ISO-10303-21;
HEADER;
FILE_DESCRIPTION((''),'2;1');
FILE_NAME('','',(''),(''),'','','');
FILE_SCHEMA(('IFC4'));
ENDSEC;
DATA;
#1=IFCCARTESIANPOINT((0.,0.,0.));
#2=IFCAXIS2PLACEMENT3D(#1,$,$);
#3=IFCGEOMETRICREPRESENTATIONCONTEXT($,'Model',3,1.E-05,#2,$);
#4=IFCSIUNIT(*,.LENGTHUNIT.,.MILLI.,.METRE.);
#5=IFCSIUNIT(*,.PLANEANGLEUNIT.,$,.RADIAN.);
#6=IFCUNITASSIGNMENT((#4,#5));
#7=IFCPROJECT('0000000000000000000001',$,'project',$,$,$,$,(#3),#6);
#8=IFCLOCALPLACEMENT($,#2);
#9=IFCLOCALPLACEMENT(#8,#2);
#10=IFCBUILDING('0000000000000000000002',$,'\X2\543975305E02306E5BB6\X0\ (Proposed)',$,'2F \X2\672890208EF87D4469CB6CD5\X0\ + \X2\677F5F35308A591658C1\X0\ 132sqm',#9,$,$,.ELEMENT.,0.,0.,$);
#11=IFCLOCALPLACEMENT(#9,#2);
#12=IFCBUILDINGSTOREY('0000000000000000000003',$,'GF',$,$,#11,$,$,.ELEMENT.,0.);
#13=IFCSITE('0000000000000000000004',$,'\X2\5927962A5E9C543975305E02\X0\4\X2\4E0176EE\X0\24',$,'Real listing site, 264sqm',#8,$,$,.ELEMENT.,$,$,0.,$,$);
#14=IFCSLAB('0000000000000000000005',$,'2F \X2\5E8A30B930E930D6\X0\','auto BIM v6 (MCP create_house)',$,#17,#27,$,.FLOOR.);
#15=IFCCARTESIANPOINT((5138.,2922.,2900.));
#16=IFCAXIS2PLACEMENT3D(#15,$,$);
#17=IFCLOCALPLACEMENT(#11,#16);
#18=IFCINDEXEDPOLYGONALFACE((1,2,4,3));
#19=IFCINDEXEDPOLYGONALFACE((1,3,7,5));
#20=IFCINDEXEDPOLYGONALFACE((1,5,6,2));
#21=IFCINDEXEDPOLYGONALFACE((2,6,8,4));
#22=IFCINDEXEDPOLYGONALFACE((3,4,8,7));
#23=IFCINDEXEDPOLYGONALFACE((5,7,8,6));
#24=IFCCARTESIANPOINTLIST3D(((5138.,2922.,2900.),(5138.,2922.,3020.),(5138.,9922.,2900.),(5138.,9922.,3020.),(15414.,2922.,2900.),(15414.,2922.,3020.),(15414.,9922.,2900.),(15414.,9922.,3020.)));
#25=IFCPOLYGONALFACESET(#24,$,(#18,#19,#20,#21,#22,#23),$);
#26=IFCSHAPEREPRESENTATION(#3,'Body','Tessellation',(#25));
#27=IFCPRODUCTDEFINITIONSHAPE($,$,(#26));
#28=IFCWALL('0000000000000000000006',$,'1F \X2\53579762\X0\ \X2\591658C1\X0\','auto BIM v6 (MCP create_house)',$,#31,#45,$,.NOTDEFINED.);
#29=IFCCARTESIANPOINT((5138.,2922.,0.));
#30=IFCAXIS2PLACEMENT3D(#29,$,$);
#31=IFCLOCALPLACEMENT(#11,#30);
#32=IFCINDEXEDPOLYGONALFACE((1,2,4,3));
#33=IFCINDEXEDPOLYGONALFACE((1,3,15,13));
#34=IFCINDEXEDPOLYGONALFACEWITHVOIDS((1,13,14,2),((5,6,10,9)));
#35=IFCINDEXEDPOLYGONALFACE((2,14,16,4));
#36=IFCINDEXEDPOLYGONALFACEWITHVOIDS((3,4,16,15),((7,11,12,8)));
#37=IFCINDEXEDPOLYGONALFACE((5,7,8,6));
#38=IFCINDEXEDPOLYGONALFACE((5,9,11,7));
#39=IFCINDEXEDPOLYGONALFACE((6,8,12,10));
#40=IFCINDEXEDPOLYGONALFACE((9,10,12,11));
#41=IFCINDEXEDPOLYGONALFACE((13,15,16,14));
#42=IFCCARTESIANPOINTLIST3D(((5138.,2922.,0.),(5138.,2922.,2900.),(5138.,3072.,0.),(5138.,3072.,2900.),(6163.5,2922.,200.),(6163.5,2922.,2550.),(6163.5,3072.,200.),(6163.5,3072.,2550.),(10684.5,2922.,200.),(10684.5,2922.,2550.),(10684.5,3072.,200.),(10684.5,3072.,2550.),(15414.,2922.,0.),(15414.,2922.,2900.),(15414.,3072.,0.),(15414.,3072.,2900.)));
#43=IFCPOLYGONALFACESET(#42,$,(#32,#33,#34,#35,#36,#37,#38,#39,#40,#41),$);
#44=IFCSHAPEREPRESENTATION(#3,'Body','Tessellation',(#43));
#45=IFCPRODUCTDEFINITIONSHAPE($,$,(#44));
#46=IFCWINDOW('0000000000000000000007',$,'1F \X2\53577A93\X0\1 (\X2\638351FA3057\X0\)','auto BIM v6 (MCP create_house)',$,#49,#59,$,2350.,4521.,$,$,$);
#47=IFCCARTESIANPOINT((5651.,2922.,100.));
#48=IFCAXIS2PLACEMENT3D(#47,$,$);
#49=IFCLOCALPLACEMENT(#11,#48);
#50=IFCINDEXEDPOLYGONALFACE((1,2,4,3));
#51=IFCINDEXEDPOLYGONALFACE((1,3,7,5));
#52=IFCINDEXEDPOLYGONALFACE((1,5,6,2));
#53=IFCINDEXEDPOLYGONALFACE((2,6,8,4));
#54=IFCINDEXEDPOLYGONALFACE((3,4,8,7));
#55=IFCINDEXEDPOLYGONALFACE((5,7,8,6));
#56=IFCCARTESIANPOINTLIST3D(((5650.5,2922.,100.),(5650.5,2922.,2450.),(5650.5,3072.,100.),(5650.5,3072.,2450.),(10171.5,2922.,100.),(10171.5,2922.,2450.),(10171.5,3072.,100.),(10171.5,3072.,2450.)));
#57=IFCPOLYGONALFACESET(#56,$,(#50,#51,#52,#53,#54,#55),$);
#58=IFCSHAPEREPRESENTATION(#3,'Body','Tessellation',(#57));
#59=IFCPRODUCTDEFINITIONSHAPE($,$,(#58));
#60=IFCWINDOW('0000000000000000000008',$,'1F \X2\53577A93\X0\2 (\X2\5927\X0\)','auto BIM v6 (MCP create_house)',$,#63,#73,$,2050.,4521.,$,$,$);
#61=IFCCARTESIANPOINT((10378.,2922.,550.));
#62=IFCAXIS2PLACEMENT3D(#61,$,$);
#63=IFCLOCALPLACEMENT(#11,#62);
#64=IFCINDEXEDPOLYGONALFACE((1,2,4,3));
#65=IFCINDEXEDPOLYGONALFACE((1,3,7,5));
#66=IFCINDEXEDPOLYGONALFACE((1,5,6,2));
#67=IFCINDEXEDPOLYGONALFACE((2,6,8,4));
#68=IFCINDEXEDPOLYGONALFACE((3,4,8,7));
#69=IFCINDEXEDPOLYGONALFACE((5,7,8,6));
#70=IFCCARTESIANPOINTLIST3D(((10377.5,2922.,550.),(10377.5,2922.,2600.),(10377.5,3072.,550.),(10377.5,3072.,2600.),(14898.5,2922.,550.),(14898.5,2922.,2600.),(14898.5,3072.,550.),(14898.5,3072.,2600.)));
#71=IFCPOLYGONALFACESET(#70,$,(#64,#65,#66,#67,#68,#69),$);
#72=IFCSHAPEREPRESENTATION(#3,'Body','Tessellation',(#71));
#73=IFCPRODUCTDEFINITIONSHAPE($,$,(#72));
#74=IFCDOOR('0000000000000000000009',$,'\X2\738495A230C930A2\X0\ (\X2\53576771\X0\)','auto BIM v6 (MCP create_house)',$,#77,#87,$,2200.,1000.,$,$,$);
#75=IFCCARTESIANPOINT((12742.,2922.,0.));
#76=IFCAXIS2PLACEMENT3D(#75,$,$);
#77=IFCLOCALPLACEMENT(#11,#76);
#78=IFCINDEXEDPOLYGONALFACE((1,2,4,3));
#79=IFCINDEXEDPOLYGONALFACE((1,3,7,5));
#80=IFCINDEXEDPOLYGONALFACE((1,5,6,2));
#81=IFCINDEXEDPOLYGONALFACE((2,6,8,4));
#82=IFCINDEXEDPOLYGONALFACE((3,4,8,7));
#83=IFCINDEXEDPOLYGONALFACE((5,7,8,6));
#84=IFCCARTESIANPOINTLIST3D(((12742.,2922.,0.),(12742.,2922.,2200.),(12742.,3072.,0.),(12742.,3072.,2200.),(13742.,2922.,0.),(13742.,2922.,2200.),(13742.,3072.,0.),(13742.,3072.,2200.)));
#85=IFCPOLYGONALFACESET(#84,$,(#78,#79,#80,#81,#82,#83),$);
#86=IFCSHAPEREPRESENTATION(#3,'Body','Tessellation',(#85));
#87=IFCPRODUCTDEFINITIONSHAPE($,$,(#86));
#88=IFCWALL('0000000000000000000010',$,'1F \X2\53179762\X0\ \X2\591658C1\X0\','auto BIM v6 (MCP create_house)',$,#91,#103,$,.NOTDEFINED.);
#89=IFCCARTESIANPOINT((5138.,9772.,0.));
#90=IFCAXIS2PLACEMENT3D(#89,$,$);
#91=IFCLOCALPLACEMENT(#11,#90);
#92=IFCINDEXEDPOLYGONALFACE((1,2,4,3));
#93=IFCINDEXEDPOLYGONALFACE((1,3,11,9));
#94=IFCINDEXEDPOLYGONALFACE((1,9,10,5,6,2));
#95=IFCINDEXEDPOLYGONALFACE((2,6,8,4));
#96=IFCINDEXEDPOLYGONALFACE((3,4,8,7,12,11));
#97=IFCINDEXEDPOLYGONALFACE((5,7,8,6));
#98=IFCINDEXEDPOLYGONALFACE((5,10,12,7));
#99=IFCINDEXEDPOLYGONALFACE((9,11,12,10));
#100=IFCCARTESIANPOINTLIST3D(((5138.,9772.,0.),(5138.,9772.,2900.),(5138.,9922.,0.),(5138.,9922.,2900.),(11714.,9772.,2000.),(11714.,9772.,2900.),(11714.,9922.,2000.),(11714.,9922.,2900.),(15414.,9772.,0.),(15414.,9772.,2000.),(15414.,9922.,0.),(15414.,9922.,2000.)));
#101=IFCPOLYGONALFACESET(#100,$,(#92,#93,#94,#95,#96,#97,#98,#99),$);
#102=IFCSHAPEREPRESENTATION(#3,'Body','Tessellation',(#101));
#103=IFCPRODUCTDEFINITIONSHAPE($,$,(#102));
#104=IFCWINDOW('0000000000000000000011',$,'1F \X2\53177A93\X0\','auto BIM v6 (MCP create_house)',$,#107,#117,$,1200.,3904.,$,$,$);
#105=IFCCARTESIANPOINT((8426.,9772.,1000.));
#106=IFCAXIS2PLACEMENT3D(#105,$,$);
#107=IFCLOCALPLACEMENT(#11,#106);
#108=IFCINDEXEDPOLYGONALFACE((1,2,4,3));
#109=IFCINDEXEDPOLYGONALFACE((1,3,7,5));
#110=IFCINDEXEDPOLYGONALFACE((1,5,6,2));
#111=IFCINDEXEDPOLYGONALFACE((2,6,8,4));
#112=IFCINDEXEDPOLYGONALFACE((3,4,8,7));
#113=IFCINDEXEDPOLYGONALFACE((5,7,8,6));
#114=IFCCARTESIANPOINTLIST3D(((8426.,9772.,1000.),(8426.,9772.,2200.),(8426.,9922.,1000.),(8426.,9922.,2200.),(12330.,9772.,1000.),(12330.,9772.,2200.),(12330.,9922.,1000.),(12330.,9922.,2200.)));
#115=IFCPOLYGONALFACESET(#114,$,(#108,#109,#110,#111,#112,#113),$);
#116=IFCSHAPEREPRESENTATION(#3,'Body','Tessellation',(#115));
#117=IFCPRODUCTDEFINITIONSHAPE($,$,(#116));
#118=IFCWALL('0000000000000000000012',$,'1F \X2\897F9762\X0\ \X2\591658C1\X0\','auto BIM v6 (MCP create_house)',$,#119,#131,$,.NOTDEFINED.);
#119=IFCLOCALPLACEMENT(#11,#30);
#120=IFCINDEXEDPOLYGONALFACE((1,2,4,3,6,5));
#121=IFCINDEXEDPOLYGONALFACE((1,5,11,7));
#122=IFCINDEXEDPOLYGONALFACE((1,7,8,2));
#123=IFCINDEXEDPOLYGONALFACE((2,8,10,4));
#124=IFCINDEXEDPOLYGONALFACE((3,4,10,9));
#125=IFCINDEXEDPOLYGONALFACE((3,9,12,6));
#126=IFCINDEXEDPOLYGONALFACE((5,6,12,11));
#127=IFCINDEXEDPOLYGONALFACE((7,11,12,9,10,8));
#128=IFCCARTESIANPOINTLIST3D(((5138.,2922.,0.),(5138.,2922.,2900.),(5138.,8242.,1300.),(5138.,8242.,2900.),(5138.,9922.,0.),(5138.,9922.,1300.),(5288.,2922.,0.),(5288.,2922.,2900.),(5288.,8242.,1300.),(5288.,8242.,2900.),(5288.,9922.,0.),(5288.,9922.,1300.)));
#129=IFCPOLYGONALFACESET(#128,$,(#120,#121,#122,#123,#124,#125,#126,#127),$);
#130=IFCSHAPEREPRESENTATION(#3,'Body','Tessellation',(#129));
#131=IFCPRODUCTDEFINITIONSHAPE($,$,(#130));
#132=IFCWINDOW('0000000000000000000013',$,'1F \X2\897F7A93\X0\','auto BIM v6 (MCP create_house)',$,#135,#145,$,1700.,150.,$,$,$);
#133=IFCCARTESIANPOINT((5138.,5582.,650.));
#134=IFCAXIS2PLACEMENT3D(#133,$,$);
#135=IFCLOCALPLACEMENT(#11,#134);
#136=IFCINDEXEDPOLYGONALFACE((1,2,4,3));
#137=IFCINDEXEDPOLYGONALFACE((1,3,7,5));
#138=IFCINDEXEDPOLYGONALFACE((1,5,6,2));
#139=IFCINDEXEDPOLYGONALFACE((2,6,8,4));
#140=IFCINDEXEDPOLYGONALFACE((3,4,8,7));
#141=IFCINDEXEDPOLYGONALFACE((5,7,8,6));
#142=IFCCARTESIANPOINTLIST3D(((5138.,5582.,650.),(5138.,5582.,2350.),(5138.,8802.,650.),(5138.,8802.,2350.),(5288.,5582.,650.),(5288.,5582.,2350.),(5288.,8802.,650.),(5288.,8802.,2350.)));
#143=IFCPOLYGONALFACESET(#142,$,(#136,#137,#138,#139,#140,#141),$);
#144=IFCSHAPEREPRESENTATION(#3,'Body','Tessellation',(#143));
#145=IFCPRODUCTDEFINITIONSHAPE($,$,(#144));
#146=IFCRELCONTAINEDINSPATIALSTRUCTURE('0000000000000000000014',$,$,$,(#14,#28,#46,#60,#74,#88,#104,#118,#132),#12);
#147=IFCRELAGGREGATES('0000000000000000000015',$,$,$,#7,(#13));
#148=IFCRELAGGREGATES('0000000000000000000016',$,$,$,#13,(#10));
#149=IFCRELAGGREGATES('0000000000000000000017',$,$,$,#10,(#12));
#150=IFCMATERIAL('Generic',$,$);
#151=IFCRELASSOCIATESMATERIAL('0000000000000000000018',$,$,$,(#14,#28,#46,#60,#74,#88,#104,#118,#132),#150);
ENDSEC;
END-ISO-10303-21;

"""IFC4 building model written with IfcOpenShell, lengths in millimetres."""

from ifc_helpers import new_model, si_unit, frame, frame_2d, origin, place, context, project, spatial, rectangle, extrude, material, element, fill, save


model = new_model("IFC4")

# Units and contexts
model_context = context("Model", 3, precision=1e-05, world=origin())
ifc_project = project(units=[si_unit("LENGTHUNIT", "METRE", prefix="MILLI"), si_unit("PLANEANGLEUNIT", "RADIAN")], contexts=[model_context])

# Site, building, storey
site_placement = place(None, origin())
site = spatial("IfcSite", under=ifc_project, at=site_placement, Name="大阪府吹田市4丁目24", ObjectType="Real listing site, 264sqm", CompositionType="ELEMENT", RefElevation=0.0)
building_placement = place(site_placement, origin())
building = spatial("IfcBuilding", under=site, at=building_placement, Name="吹田市の家 (Proposed)", ObjectType="2F 木造軸組構法 + 板張り外壁 132sqm", CompositionType="ELEMENT", ElevationOfRefHeight=0.0, ElevationOfTerrain=0.0)
storey_placement = place(building_placement, origin())
storey = spatial("IfcBuildingStorey", under=building, at=storey_placement, Name="GF", CompositionType="ELEMENT", Elevation=0.0)

# Slab
ifc_material = material(Name="Generic")
slab_1_placement = place(storey_placement, frame((5138.0, 2922.0, 2900.0)))
element("IfcSlab", 1, at=slab_1_placement, inside=storey, material=ifc_material, Name="2F 床スラブ", Description="auto BIM v6 (MCP create_house)", PredefinedType="FLOOR", context=model_context, shape_type="SweptSolid", body=[
    extrude(rectangle(XDim=10276.0, YDim=7000.0, at=frame_2d((5138.0, 3500.0))), frame((5138.0, 2922.0, 2900.0)), (0.0, 0.0, 1.0), 120.0),
])

# Wall, openings, windows, door
wall_1_placement = place(storey_placement, frame((5138.0, 2922.0, 0.0)))
wall_1 = element("IfcWall", 2, at=wall_1_placement, inside=storey, material=ifc_material, Name="1F 南面 外壁", Description="auto BIM v6 (MCP create_house)", PredefinedType="NOTDEFINED", context=model_context, shape_type="SweptSolid", body=[
    extrude(rectangle(XDim=10276.0, YDim=150.0, at=frame_2d((5138.0, 75.0))), frame((5138.0, 2922.0, 0.0)), (0.0, 0.0, 1.0), 2900.0),
])
opening_1_placement = place(storey_placement, frame((5651.0, 2922.0, 100.0)))
opening_1 = element("IfcOpeningElement", 3, at=opening_1_placement, cuts=wall_1, PredefinedType="NOTDEFINED", context=model_context, shape_type="SweptSolid", body=[
    extrude(rectangle(XDim=4521.0, YDim=150.0, at=frame_2d((2260.0, 75.0))), frame((5651.0, 2922.0, 100.0)), (0.0, 0.0, 1.0), 2350.0),
])
opening_2_placement = place(storey_placement, frame((10378.0, 2922.0, 550.0)))
opening_2 = element("IfcOpeningElement", 4, at=opening_2_placement, cuts=wall_1, PredefinedType="NOTDEFINED", context=model_context, shape_type="SweptSolid", body=[
    extrude(rectangle(XDim=4521.0, YDim=150.0, at=frame_2d((2260.0, 75.0))), frame((10378.0, 2922.0, 550.0)), (0.0, 0.0, 1.0), 2050.0),
])
opening_3_placement = place(storey_placement, frame((12742.0, 2922.0, 0.0)))
opening_3 = element("IfcOpeningElement", 5, at=opening_3_placement, cuts=wall_1, PredefinedType="NOTDEFINED", context=model_context, shape_type="SweptSolid", body=[
    extrude(rectangle(XDim=1000.0, YDim=150.0, at=frame_2d((500.0, 75.0))), frame((12742.0, 2922.0, 0.0)), (0.0, 0.0, 1.0), 2200.0),
])
window_1_placement = place(storey_placement, frame((5651.0, 2922.0, 100.0)))
window_1 = element("IfcWindow", 6, at=window_1_placement, inside=storey, material=ifc_material, Name="1F 南窓1 (掃出し)", Description="auto BIM v6 (MCP create_house)", OverallHeight=2350.0, OverallWidth=4521.0, context=model_context, shape_type="SweptSolid", body=[
    extrude(rectangle(XDim=4521.0, YDim=150.0, at=frame_2d((2260.0, 75.0))), frame((5651.0, 2922.0, 100.0)), (0.0, 0.0, 1.0), 2350.0),
])
fill(opening_1, window_1)
window_2_placement = place(storey_placement, frame((10378.0, 2922.0, 550.0)))
window_2 = element("IfcWindow", 7, at=window_2_placement, inside=storey, material=ifc_material, Name="1F 南窓2 (大)", Description="auto BIM v6 (MCP create_house)", OverallHeight=2050.0, OverallWidth=4521.0, context=model_context, shape_type="SweptSolid", body=[
    extrude(rectangle(XDim=4521.0, YDim=150.0, at=frame_2d((2260.0, 75.0))), frame((10378.0, 2922.0, 550.0)), (0.0, 0.0, 1.0), 2050.0),
])
fill(opening_2, window_2)
door_placement = place(storey_placement, frame((12742.0, 2922.0, 0.0)))
door = element("IfcDoor", 8, at=door_placement, inside=storey, material=ifc_material, Name="玄関ドア (南東)", Description="auto BIM v6 (MCP create_house)", OverallHeight=2200.0, OverallWidth=1000.0, context=model_context, shape_type="SweptSolid", body=[
    extrude(rectangle(XDim=1000.0, YDim=150.0, at=frame_2d((500.0, 75.0))), frame((12742.0, 2922.0, 0.0)), (0.0, 0.0, 1.0), 2200.0),
])
fill(opening_3, door)

# Walls, openings, windows
wall_2_placement = place(storey_placement, frame((5138.0, 9772.0, 0.0)))
wall_2 = element("IfcWall", 9, at=wall_2_placement, inside=storey, material=ifc_material, Name="1F 北面 外壁", Description="auto BIM v6 (MCP create_house)", PredefinedType="NOTDEFINED", context=model_context, shape_type="SweptSolid", body=[
    extrude(rectangle(XDim=10276.0, YDim=150.0, at=frame_2d((5138.0, 75.0))), frame((5138.0, 9772.0, 0.0)), (0.0, 0.0, 1.0), 2900.0),
])
opening_4_placement = place(storey_placement, frame((8426.0, 9772.0, 1000.0)))
opening_4 = element("IfcOpeningElement", 10, at=opening_4_placement, cuts=wall_2, PredefinedType="NOTDEFINED", context=model_context, shape_type="SweptSolid", body=[
    extrude(rectangle(XDim=3904.0, YDim=150.0, at=frame_2d((1952.0, 75.0))), frame((8426.0, 9772.0, 1000.0)), (0.0, 0.0, 1.0), 1200.0),
])
window_3_placement = place(storey_placement, frame((8426.0, 9772.0, 1000.0)))
window_3 = element("IfcWindow", 11, at=window_3_placement, inside=storey, material=ifc_material, Name="1F 北窓", Description="auto BIM v6 (MCP create_house)", OverallHeight=1200.0, OverallWidth=3904.0, context=model_context, shape_type="SweptSolid", body=[
    extrude(rectangle(XDim=3904.0, YDim=150.0, at=frame_2d((1952.0, 75.0))), frame((8426.0, 9772.0, 1000.0)), (0.0, 0.0, 1.0), 1200.0),
])
fill(opening_4, window_3)
wall_3_placement = place(storey_placement, frame((5138.0, 2922.0, 0.0)))
wall_3 = element("IfcWall", 12, at=wall_3_placement, inside=storey, material=ifc_material, Name="1F 西面 外壁", Description="auto BIM v6 (MCP create_house)", PredefinedType="NOTDEFINED", context=model_context, shape_type="SweptSolid", body=[
    extrude(rectangle(XDim=150.0, YDim=7000.0, at=frame_2d((75.0, 3500.0))), frame((5138.0, 2922.0, 0.0)), (0.0, 0.0, 1.0), 2900.0),
])
opening_5_placement = place(storey_placement, frame((5138.0, 5582.0, 650.0)))
opening_5 = element("IfcOpeningElement", 13, at=opening_5_placement, cuts=wall_3, PredefinedType="NOTDEFINED", context=model_context, shape_type="SweptSolid", body=[
    extrude(rectangle(XDim=150.0, YDim=3220.0, at=frame_2d((75.0, 1610.0))), frame((5138.0, 5582.0, 650.0)), (0.0, 0.0, 1.0), 1700.0),
])
window_4_placement = place(storey_placement, frame((5138.0, 5582.0, 650.0)))
window_4 = element("IfcWindow", 14, at=window_4_placement, inside=storey, material=ifc_material, Name="1F 西窓", Description="auto BIM v6 (MCP create_house)", OverallHeight=1700.0, OverallWidth=150.0, context=model_context, shape_type="SweptSolid", body=[
    extrude(rectangle(XDim=150.0, YDim=3220.0, at=frame_2d((75.0, 1610.0))), frame((5138.0, 5582.0, 650.0)), (0.0, 0.0, 1.0), 1700.0),
])
fill(opening_5, window_4)

save(model, "model.ifc")
